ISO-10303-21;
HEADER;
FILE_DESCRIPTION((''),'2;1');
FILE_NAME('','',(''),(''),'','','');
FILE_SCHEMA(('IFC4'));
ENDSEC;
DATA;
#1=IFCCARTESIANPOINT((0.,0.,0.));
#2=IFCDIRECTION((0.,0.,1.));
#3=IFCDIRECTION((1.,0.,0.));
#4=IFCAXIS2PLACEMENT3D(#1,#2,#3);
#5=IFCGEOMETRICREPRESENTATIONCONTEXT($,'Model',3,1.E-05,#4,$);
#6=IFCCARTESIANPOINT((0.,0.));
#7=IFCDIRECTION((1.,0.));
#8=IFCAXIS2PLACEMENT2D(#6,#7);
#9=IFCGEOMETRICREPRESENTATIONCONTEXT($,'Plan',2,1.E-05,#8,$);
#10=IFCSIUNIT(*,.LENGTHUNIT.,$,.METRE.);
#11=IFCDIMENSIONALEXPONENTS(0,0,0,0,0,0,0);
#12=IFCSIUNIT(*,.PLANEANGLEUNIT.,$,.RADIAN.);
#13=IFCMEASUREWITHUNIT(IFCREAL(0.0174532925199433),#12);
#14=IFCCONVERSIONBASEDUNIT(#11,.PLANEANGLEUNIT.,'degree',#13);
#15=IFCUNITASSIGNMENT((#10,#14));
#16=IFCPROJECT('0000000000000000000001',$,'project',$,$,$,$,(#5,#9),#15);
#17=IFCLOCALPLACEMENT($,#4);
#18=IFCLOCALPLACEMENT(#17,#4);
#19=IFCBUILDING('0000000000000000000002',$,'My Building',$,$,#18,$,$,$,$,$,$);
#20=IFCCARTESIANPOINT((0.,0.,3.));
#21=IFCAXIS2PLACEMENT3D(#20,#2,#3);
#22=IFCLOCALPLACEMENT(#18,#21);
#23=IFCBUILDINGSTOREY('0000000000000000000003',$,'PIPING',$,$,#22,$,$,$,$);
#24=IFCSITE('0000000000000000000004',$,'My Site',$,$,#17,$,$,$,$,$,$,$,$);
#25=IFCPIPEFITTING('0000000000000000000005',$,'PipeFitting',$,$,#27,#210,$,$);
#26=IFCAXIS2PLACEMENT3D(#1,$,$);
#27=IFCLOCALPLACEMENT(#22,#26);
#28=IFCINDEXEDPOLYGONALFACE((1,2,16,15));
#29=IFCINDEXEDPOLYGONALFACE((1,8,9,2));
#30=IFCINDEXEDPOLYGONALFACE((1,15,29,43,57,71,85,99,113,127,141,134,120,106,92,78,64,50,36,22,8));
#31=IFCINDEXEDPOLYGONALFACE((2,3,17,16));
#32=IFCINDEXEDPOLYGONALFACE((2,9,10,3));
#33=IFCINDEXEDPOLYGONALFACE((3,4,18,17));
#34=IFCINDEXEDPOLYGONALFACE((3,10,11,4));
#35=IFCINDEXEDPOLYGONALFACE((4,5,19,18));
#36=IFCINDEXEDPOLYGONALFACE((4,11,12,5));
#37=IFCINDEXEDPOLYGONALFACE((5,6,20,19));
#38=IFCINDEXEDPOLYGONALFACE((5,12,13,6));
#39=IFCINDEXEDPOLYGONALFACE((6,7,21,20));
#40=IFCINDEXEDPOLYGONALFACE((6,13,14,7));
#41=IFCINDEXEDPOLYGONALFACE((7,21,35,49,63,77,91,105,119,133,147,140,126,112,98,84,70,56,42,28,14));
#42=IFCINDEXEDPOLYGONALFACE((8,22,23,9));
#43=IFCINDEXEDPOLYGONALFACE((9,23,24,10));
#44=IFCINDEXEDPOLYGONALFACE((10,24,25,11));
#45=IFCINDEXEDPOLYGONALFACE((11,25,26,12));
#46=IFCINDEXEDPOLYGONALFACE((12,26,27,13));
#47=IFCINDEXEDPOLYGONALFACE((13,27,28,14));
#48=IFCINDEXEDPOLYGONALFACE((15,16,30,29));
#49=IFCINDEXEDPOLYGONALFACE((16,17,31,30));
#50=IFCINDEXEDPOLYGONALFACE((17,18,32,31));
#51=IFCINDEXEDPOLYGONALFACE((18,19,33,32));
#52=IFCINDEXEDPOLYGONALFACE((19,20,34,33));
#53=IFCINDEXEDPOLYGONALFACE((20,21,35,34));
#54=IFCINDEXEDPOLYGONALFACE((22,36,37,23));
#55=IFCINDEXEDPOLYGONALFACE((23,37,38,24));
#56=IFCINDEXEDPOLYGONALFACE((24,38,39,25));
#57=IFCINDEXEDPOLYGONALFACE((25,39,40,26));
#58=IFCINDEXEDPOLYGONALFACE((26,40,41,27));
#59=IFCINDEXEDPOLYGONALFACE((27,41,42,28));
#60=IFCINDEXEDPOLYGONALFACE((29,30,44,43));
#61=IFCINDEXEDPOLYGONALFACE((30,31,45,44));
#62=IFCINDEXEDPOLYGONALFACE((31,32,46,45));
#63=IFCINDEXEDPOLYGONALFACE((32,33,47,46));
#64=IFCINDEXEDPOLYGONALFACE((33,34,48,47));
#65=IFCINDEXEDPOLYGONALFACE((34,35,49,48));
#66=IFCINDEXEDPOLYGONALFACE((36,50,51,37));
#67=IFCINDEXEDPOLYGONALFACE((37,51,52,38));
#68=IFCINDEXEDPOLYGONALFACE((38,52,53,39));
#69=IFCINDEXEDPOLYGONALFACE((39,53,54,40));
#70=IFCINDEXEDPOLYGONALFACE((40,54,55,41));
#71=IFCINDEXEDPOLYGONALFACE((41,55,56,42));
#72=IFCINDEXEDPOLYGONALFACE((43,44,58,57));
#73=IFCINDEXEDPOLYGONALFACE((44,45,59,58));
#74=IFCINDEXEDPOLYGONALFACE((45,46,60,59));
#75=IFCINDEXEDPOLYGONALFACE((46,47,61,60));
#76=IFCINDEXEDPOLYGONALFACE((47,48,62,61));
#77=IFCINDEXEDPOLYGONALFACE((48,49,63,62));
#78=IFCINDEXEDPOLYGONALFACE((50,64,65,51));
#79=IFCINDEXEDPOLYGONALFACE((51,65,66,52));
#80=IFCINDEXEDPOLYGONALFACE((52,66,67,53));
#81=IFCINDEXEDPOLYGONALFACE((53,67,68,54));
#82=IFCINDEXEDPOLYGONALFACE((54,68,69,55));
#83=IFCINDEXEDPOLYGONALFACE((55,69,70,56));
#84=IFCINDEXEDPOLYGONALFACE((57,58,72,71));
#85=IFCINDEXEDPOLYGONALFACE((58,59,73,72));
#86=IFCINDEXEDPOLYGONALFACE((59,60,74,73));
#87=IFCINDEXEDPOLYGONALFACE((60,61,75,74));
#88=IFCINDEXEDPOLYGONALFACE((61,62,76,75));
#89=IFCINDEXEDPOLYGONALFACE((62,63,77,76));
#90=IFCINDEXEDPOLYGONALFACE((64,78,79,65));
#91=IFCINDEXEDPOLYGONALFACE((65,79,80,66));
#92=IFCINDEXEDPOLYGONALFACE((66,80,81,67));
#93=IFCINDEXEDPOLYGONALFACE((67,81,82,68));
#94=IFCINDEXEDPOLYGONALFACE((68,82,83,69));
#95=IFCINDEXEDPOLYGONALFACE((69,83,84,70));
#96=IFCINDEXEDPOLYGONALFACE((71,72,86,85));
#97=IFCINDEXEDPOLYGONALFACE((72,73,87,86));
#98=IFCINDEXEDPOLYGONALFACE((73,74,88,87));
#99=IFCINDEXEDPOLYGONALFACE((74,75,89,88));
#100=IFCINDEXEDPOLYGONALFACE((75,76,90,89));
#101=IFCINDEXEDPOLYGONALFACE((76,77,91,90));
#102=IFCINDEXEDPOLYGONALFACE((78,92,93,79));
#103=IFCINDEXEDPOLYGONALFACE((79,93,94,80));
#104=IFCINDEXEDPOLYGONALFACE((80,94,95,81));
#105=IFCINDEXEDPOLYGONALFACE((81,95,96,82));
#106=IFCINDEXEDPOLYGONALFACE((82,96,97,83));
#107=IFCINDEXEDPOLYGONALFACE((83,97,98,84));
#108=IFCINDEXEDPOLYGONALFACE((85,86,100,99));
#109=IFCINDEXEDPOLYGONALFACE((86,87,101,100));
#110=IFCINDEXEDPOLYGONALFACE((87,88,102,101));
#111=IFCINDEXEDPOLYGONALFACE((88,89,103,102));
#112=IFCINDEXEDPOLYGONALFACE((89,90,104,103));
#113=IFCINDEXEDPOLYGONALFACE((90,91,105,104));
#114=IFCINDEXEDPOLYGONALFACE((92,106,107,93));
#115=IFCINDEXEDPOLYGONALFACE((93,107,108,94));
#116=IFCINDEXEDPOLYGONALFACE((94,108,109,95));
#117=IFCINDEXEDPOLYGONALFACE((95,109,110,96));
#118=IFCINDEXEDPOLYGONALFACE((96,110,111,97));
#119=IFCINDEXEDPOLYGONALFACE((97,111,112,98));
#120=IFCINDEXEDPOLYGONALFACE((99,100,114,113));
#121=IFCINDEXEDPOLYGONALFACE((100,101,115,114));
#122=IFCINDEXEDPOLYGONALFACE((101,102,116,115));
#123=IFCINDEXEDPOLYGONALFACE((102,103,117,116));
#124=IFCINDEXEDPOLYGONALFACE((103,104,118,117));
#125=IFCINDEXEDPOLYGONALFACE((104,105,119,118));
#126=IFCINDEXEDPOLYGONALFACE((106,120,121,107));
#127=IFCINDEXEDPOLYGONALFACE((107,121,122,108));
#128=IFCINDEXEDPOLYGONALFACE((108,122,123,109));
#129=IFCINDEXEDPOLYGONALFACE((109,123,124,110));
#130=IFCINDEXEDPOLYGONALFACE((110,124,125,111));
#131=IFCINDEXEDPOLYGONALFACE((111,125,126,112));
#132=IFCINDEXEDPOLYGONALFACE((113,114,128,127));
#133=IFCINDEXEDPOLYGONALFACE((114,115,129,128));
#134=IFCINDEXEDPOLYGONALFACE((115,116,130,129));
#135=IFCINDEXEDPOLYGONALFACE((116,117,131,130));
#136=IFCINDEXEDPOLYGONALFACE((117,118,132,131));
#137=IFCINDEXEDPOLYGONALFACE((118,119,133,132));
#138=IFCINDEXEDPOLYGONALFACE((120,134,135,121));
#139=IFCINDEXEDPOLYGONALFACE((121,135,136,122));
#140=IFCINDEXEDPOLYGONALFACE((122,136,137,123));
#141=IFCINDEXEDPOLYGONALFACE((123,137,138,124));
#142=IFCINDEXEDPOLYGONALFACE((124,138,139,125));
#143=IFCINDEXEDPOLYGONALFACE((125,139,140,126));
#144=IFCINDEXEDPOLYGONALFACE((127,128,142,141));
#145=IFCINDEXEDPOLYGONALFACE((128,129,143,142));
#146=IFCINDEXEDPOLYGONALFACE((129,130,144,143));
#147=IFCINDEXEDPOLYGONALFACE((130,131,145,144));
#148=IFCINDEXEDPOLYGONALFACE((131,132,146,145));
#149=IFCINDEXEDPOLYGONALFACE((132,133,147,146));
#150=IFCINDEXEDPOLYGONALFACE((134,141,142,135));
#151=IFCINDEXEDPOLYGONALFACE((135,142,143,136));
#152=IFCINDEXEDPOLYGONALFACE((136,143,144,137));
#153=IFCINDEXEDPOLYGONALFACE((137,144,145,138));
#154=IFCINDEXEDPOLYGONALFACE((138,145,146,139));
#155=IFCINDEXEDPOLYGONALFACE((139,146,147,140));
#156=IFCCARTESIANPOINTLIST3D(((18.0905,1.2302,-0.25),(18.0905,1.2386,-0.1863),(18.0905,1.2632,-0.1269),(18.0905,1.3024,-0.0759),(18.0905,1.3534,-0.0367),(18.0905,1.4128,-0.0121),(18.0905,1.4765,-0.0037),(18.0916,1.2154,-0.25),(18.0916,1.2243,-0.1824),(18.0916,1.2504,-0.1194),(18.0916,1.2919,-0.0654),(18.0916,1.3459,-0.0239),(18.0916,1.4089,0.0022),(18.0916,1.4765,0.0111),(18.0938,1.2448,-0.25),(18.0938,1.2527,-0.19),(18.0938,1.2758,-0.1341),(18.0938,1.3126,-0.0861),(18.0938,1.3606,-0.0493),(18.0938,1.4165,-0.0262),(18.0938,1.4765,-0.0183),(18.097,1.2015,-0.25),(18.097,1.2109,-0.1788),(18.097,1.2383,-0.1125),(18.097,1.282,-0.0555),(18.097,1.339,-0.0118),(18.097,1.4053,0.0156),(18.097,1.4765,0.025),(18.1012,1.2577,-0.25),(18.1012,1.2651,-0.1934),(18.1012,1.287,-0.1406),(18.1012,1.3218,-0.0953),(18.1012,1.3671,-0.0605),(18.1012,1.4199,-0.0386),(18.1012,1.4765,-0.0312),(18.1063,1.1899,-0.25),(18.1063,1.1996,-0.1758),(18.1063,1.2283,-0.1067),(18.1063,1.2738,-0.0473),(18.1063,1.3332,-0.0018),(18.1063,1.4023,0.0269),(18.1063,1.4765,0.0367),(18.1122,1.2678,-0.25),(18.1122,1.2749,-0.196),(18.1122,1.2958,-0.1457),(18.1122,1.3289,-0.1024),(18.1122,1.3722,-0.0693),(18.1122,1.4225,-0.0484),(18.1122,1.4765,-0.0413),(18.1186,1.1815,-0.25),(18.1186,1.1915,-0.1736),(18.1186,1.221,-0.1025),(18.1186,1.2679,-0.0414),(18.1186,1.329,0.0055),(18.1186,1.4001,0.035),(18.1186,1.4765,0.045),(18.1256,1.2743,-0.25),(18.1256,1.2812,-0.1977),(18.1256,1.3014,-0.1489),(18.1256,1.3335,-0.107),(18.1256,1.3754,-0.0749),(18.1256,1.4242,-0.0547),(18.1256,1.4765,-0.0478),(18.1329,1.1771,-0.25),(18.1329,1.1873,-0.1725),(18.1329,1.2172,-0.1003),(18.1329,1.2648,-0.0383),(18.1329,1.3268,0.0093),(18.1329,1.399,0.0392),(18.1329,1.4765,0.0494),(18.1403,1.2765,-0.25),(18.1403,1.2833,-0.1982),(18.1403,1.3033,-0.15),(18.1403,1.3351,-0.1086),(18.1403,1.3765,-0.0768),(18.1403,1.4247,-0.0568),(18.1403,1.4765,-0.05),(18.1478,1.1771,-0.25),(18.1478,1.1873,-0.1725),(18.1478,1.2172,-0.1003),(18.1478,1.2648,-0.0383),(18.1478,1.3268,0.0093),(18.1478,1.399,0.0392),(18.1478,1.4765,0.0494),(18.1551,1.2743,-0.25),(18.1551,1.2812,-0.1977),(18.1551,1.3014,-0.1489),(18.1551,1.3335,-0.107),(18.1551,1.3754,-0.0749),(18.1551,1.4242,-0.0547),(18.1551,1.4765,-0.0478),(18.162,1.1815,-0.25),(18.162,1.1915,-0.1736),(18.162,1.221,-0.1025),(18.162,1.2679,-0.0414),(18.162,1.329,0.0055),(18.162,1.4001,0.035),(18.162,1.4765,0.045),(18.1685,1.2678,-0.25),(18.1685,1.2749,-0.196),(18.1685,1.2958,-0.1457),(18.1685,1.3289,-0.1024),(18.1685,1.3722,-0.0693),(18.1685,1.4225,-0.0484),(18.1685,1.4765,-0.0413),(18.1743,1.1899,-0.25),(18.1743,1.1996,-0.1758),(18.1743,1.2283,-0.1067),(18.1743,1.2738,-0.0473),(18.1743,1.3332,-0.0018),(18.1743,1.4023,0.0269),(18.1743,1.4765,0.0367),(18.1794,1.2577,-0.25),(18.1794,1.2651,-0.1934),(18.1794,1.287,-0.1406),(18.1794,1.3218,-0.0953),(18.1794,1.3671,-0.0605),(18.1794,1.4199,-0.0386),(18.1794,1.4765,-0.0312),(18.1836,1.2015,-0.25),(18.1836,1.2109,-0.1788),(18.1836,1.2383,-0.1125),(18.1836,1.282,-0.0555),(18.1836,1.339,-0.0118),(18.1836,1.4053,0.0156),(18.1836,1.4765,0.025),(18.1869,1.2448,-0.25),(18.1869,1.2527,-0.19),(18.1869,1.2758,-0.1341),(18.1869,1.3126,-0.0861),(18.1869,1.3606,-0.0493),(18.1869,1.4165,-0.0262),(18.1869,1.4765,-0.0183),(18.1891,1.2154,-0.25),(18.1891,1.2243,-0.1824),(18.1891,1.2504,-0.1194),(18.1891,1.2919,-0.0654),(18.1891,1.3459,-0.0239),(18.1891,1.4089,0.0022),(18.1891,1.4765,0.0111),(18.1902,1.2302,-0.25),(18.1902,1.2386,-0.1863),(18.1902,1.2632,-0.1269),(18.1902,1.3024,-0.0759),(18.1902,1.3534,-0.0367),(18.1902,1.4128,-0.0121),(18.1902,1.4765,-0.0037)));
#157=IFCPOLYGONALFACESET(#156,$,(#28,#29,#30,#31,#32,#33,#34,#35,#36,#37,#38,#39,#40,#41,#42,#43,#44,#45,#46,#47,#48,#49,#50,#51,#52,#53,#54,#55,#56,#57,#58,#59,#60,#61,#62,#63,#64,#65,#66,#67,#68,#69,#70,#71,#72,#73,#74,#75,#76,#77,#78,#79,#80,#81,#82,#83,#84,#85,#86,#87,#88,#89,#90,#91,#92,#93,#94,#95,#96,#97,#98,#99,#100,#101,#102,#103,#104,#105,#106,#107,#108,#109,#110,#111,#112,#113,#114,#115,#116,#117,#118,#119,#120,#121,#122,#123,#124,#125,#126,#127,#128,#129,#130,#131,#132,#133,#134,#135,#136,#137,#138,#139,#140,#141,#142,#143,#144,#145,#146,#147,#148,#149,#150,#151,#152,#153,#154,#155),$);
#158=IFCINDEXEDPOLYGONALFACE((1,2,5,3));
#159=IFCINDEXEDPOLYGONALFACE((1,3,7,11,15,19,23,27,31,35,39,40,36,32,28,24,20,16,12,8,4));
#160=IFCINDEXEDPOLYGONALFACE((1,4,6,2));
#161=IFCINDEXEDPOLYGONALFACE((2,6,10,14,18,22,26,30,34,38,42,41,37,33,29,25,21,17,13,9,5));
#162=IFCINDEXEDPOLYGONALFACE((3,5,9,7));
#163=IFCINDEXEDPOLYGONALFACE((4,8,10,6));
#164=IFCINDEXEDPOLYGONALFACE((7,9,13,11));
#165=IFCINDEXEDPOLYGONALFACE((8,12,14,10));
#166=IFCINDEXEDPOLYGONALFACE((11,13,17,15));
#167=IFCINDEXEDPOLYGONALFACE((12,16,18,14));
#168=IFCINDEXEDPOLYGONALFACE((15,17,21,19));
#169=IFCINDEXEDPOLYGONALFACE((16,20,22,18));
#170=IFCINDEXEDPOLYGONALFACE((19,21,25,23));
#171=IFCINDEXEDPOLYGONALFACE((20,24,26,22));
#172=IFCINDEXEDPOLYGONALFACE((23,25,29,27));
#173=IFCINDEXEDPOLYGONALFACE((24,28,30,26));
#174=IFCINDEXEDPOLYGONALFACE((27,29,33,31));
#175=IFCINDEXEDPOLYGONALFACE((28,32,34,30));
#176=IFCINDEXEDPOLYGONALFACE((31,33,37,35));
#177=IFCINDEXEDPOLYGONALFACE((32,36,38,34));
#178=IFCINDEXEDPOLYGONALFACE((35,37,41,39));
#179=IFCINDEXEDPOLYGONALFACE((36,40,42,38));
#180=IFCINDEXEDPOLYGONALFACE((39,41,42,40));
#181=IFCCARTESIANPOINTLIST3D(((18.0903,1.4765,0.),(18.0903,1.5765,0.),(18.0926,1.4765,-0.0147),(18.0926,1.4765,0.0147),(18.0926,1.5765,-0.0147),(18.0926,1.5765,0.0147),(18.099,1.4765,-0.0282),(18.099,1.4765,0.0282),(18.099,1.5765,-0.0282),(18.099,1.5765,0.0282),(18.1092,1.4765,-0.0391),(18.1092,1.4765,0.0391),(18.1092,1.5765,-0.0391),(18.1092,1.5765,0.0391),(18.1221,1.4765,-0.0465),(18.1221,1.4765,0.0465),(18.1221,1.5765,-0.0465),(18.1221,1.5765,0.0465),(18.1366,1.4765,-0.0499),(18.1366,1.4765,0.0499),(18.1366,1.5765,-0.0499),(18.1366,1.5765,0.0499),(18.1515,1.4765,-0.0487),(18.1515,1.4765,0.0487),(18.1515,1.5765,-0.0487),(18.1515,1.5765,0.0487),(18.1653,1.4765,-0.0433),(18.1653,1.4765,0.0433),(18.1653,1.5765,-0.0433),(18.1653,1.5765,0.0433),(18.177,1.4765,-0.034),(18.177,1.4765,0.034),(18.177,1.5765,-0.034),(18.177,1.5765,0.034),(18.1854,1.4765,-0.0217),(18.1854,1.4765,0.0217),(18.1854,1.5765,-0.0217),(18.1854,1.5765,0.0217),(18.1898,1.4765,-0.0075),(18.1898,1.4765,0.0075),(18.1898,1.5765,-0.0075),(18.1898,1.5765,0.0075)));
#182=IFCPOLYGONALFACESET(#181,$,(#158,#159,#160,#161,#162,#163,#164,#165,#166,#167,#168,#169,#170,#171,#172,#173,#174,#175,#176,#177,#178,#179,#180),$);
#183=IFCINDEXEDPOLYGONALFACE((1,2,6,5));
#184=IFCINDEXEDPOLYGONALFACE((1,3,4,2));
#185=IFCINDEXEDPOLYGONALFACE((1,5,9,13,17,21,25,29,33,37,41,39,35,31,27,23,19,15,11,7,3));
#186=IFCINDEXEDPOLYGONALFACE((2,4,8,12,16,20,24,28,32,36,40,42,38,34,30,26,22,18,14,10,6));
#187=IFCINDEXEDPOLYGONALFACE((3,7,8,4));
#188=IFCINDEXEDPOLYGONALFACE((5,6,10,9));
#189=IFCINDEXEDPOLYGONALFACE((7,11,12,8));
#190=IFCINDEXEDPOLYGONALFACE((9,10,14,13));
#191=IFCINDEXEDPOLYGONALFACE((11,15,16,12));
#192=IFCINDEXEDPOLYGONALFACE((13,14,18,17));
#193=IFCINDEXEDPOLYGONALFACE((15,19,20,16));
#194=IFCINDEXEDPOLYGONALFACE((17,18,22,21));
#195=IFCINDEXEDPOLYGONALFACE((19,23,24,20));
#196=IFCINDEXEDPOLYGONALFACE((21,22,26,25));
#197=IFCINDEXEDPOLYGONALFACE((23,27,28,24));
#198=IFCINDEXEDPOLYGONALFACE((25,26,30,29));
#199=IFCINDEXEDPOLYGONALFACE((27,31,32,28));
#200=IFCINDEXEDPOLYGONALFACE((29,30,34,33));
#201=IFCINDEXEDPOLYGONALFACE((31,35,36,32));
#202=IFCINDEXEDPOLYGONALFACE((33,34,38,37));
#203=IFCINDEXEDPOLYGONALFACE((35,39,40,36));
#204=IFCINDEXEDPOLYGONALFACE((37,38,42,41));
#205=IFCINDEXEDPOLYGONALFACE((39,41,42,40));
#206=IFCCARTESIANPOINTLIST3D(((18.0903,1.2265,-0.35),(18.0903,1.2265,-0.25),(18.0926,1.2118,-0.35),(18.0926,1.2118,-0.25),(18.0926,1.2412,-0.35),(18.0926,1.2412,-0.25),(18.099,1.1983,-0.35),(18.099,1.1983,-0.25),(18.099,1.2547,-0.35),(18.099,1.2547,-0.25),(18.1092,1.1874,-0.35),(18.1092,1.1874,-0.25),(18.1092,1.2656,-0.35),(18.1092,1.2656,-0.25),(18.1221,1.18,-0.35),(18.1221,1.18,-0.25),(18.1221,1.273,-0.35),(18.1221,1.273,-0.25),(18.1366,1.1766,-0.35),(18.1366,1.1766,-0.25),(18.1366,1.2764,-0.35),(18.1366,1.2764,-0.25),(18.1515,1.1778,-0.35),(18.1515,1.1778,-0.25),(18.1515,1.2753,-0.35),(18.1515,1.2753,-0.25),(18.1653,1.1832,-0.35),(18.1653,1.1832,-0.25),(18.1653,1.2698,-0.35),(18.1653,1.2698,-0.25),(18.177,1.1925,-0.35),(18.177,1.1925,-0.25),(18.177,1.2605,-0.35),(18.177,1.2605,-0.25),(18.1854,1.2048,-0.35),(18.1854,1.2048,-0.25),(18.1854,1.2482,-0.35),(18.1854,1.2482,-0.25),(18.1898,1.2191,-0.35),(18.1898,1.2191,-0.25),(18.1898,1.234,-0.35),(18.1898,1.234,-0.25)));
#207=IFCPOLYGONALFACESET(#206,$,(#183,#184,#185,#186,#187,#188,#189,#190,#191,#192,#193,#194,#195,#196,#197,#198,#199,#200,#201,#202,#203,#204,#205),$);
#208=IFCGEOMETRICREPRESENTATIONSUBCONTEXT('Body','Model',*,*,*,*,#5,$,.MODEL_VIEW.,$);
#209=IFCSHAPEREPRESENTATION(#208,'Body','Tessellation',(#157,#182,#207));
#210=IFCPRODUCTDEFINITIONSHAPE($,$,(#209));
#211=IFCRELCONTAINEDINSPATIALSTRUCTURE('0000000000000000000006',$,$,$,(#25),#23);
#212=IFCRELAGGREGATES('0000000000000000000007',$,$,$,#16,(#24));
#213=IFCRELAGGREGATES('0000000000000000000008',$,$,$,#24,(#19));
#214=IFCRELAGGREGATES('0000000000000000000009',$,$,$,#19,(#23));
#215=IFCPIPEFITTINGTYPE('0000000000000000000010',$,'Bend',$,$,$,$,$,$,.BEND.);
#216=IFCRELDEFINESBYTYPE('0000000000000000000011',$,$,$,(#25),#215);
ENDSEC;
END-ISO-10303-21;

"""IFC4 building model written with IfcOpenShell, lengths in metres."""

from ifc_helpers import new_model, entity, si_unit, converted_unit, frame, origin_with_axes, origin_2d_with_axis, place, context, subcontext, project, spatial, circle, extrude, source, transform, mapped, type_object, type_shapes, element, save


model = new_model("IFC4")

# Units and contexts
model_context = context("Model", 3, precision=1e-05, world=origin_with_axes())
plan_context = context("Plan", 2, precision=1e-05, world=origin_2d_with_axis())
body_context = subcontext(model_context, "Body", "Model", "MODEL_VIEW")
ifc_project = project(units=[si_unit("LENGTHUNIT", "METRE"), converted_unit("PLANEANGLEUNIT", "degree", entity("IfcReal", 0.0174532925199433), si_unit("PLANEANGLEUNIT", "RADIAN"), dimensions=[0, 0, 0, 0, 0, 0, 0])], contexts=[model_context, plan_context])

# Site, building, storey
site_placement = place(None, origin_with_axes())
site = spatial("IfcSite", under=ifc_project, at=site_placement, Name="My Site")
building_placement = place(site_placement, origin_with_axes())
building = spatial("IfcBuilding", under=site, at=building_placement, Name="My Building")
storey_placement = place(building_placement, frame((0.0, 0.0, 3.0), z_axis=(0.0, 0.0, 1.0), x_axis=(1.0, 0.0, 0.0)))
storey = spatial("IfcBuildingStorey", under=building, at=storey_placement, Name="PIPING")

# Pipe fitting
pipe_fitting_type = type_object("IfcPipeFittingType", Name="Bend", PredefinedType="BEND")
shared_shape = source(origin_with_axes(), body_context, "Body", "SolidModel", [
    entity("IfcSweptDiskSolid", entity("IfcIndexedPolyCurve", entity("IfcCartesianPointList3D", [[0.0, 0.0, -0.1], [0.0, -0.0732, -0.2768], [0.0, -0.25, -0.35]]), [entity("IfcArcIndex", [1, 2, 3])]), 0.05),
    extrude(circle(Radius=0.05), origin_with_axes(), (0.0, 0.0, -1.0), 0.1),
    extrude(circle(Radius=0.05), frame((0.0, -0.25, -0.35), z_axis=(0.0, -1.0, 0.0), x_axis=(1.0, 0.0, 0.0)), (0.0, 0.0, 1.0), 0.1),
])
type_shapes(pipe_fitting_type, [shared_shape])
for number, where, z_axis, x_axis, name in (
    (1, (18.1403, 1.5765, 0.0), (0.0, 1.0, 0.0), (-1.0, 0.0, 0.0), "PipeFitting"),
):
    element("IfcPipeFitting", number, at=place(storey_placement, frame(where, z_axis=z_axis, x_axis=x_axis)), inside=storey, type_object=pipe_fitting_type, Name=name, context=body_context, shape_type="MappedRepresentation", body=[
        mapped(shared_shape, transform((0.0, 0.0, 0.0), x_axis=(1.0, 0.0, 0.0), y_axis=(0.0, 1.0, 0.0), z_axis=(0.0, 0.0, 1.0), scale=1.0)),
    ])

save(model, "model.ifc")
